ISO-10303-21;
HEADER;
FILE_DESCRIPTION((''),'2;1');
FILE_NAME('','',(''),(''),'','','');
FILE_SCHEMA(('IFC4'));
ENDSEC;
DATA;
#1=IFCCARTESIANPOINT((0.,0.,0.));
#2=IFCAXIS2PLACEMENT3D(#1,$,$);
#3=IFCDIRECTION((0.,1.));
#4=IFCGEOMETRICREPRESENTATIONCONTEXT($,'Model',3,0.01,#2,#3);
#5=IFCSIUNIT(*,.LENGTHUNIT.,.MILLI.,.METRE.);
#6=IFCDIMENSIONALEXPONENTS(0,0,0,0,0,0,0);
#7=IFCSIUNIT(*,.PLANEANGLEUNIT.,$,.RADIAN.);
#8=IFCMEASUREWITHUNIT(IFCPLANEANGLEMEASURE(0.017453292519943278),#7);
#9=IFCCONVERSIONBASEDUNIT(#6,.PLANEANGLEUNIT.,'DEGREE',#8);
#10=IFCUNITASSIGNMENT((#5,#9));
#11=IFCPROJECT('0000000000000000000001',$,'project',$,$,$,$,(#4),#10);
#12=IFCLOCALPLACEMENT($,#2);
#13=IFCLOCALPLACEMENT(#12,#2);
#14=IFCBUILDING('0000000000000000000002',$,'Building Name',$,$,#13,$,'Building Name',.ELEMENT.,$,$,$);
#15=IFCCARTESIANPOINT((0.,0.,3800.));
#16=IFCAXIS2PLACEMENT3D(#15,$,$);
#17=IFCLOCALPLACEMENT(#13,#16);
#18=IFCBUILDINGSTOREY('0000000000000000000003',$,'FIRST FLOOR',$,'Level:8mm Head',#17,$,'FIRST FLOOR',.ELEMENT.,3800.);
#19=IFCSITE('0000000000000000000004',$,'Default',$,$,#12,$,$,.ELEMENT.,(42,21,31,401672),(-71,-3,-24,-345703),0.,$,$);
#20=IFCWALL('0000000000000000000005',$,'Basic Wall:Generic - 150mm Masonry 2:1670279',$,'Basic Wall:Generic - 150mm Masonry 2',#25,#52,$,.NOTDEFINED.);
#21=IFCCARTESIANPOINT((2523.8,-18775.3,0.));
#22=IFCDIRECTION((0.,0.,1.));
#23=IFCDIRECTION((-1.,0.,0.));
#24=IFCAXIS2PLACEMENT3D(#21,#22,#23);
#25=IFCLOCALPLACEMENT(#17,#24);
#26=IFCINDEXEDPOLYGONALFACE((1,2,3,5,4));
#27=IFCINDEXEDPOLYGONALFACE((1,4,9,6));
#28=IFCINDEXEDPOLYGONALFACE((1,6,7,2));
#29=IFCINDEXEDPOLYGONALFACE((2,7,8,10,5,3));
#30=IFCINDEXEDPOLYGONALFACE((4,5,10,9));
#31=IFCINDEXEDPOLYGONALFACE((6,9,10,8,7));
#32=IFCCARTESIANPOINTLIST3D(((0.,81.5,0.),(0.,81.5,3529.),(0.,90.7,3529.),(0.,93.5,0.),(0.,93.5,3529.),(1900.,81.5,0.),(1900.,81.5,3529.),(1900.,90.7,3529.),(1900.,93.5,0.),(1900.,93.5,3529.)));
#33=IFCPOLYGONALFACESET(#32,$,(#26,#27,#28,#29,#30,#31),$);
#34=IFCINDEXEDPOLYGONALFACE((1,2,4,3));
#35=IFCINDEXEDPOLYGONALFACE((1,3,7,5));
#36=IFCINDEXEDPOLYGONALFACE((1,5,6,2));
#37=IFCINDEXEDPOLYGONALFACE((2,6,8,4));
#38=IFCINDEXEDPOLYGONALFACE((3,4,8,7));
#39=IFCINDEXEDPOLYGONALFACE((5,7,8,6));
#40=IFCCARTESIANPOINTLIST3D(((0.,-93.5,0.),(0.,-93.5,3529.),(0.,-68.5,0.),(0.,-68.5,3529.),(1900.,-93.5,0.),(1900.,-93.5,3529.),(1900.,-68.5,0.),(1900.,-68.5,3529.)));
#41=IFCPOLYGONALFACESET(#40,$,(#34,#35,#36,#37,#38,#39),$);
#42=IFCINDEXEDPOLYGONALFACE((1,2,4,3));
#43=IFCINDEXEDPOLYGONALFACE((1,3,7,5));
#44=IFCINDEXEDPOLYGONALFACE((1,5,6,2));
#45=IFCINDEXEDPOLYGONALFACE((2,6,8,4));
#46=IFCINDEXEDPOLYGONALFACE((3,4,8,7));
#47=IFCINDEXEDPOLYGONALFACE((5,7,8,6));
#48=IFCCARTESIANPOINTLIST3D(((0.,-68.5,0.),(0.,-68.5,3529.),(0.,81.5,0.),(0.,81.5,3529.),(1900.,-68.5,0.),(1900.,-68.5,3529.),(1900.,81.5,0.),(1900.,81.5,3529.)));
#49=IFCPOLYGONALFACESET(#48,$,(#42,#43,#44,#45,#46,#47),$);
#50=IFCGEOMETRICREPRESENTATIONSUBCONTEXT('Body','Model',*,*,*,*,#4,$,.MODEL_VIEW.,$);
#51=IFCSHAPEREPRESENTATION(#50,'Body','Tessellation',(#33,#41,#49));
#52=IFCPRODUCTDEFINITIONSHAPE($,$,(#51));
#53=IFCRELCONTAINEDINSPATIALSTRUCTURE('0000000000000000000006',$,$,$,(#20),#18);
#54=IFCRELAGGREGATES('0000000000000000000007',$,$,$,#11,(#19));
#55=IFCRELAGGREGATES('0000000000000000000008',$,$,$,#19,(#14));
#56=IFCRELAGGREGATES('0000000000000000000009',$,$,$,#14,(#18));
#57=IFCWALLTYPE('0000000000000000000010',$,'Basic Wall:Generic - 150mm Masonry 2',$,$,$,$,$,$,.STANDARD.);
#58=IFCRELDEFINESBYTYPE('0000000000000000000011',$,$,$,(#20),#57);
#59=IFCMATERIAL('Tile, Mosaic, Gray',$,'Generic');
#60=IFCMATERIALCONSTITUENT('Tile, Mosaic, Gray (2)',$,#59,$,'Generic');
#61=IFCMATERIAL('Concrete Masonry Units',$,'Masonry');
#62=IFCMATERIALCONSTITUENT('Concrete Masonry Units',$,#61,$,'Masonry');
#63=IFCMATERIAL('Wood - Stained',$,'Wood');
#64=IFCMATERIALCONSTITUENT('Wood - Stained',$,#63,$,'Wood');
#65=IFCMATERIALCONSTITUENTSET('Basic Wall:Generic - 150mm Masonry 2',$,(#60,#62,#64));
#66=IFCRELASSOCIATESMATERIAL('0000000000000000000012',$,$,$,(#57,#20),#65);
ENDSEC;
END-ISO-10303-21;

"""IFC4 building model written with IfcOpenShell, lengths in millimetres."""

from ifc_helpers import new_model, entity, si_unit, converted_unit, direction, frame, origin, place, context, subcontext, project, spatial, indexed_curve, outline, extrude, material, constituent, constituent_set, type_object, element, save


model = new_model("IFC4")

# Units and contexts
model_context = context("Model", 3, precision=0.01, world=origin(), true_north=direction((0.0, 1.0)))
body_context = subcontext(model_context, "Body", "Model", "MODEL_VIEW")
ifc_project = project(units=[si_unit("LENGTHUNIT", "METRE", prefix="MILLI"), converted_unit("PLANEANGLEUNIT", "DEGREE", entity("IfcPlaneAngleMeasure", 0.017453292519943278), si_unit("PLANEANGLEUNIT", "RADIAN"), dimensions=[0, 0, 0, 0, 0, 0, 0])], contexts=[model_context])

# Site, building, storey
site_placement = place(None, origin())
site = spatial("IfcSite", under=ifc_project, at=site_placement, Name="Default", CompositionType="ELEMENT", RefLatitude=(42, 21, 31, 401672), RefLongitude=(-71, -3, -24, -345703), RefElevation=0.0)
building_placement = place(site_placement, origin())
building = spatial("IfcBuilding", under=site, at=building_placement, Name="Building Name", LongName="Building Name", CompositionType="ELEMENT")
storey_placement = place(building_placement, frame((0.0, 0.0, 3800.0)))
storey = spatial("IfcBuildingStorey", under=building, at=storey_placement, Name="FIRST FLOOR", ObjectType="Level:8mm Head", LongName="FIRST FLOOR", CompositionType="ELEMENT", Elevation=3800.0)

# Wall
ifc_material_1 = material(Name="Tile, Mosaic, Gray", Category="Generic")
ifc_constituent_1 = constituent(ifc_material_1, Name="Tile, Mosaic, Gray (2)", Category="Generic")
ifc_material_2 = material(Name="Concrete Masonry Units", Category="Masonry")
ifc_constituent_2 = constituent(ifc_material_2, Name="Concrete Masonry Units", Category="Masonry")
ifc_material_3 = material(Name="Wood - Stained", Category="Wood")
ifc_constituent_3 = constituent(ifc_material_3, Name="Wood - Stained", Category="Wood")
ifc_constituent_set_1 = constituent_set(constituents=[ifc_constituent_1, ifc_constituent_2, ifc_constituent_3], Name="Basic Wall:Generic - 150mm Masonry 2")
wall_type_1 = type_object("IfcWallType", Name="Basic Wall:Generic - 150mm Masonry 2", PredefinedType="STANDARD", material=ifc_constituent_set_1)
wall_1_placement = place(storey_placement, frame((2523.8, -18775.3, 0.0), z_axis=(0.0, 0.0, 1.0), x_axis=(-1.0, 0.0, 0.0)))
element("IfcWall", 1, at=wall_1_placement, inside=storey, type_object=wall_type_1, material=ifc_constituent_set_1, Name="Basic Wall:Generic - 150mm Masonry 2:1670279", ObjectType="Basic Wall:Generic - 150mm Masonry 2", PredefinedType="NOTDEFINED", context=body_context, shape_type="SweptSolid", body=[
    extrude(outline(indexed_curve([(-5.4, -2117.4), (6.6, -2117.4), (6.6, 1411.6), (-2.6, 1411.6), (-5.4, 1411.6), (-5.4, -2117.4)], self_intersect=False)), frame((1900.0, 88.1, 2117.4), z_axis=(-1.0, 0.0, 0.0), x_axis=(0.0, -1.0, 0.0)), (0.0, 0.0, 1.0), 1900.0),
    extrude(outline(indexed_curve([(-12.5, -1764.5), (12.5, -1764.5), (12.5, 1764.5), (-12.5, 1764.5), (-12.5, -1764.5)], self_intersect=False)), frame((1900.0, -81.0, 1764.5), z_axis=(-1.0, 0.0, 0.0), x_axis=(0.0, 1.0, 0.0)), (0.0, 0.0, 1.0), 1900.0),
    extrude(outline(indexed_curve([(-1764.5, -75.0), (1764.5, -75.0), (1764.5, 75.0), (-1764.5, 75.0), (-1764.5, -75.0)], self_intersect=False)), frame((1900.0, 6.5, 1764.5), z_axis=(-1.0, 0.0, 0.0), x_axis=(0.0, 0.0, 1.0)), (0.0, 0.0, 1.0), 1900.0),
])

save(model, "model.ifc")
